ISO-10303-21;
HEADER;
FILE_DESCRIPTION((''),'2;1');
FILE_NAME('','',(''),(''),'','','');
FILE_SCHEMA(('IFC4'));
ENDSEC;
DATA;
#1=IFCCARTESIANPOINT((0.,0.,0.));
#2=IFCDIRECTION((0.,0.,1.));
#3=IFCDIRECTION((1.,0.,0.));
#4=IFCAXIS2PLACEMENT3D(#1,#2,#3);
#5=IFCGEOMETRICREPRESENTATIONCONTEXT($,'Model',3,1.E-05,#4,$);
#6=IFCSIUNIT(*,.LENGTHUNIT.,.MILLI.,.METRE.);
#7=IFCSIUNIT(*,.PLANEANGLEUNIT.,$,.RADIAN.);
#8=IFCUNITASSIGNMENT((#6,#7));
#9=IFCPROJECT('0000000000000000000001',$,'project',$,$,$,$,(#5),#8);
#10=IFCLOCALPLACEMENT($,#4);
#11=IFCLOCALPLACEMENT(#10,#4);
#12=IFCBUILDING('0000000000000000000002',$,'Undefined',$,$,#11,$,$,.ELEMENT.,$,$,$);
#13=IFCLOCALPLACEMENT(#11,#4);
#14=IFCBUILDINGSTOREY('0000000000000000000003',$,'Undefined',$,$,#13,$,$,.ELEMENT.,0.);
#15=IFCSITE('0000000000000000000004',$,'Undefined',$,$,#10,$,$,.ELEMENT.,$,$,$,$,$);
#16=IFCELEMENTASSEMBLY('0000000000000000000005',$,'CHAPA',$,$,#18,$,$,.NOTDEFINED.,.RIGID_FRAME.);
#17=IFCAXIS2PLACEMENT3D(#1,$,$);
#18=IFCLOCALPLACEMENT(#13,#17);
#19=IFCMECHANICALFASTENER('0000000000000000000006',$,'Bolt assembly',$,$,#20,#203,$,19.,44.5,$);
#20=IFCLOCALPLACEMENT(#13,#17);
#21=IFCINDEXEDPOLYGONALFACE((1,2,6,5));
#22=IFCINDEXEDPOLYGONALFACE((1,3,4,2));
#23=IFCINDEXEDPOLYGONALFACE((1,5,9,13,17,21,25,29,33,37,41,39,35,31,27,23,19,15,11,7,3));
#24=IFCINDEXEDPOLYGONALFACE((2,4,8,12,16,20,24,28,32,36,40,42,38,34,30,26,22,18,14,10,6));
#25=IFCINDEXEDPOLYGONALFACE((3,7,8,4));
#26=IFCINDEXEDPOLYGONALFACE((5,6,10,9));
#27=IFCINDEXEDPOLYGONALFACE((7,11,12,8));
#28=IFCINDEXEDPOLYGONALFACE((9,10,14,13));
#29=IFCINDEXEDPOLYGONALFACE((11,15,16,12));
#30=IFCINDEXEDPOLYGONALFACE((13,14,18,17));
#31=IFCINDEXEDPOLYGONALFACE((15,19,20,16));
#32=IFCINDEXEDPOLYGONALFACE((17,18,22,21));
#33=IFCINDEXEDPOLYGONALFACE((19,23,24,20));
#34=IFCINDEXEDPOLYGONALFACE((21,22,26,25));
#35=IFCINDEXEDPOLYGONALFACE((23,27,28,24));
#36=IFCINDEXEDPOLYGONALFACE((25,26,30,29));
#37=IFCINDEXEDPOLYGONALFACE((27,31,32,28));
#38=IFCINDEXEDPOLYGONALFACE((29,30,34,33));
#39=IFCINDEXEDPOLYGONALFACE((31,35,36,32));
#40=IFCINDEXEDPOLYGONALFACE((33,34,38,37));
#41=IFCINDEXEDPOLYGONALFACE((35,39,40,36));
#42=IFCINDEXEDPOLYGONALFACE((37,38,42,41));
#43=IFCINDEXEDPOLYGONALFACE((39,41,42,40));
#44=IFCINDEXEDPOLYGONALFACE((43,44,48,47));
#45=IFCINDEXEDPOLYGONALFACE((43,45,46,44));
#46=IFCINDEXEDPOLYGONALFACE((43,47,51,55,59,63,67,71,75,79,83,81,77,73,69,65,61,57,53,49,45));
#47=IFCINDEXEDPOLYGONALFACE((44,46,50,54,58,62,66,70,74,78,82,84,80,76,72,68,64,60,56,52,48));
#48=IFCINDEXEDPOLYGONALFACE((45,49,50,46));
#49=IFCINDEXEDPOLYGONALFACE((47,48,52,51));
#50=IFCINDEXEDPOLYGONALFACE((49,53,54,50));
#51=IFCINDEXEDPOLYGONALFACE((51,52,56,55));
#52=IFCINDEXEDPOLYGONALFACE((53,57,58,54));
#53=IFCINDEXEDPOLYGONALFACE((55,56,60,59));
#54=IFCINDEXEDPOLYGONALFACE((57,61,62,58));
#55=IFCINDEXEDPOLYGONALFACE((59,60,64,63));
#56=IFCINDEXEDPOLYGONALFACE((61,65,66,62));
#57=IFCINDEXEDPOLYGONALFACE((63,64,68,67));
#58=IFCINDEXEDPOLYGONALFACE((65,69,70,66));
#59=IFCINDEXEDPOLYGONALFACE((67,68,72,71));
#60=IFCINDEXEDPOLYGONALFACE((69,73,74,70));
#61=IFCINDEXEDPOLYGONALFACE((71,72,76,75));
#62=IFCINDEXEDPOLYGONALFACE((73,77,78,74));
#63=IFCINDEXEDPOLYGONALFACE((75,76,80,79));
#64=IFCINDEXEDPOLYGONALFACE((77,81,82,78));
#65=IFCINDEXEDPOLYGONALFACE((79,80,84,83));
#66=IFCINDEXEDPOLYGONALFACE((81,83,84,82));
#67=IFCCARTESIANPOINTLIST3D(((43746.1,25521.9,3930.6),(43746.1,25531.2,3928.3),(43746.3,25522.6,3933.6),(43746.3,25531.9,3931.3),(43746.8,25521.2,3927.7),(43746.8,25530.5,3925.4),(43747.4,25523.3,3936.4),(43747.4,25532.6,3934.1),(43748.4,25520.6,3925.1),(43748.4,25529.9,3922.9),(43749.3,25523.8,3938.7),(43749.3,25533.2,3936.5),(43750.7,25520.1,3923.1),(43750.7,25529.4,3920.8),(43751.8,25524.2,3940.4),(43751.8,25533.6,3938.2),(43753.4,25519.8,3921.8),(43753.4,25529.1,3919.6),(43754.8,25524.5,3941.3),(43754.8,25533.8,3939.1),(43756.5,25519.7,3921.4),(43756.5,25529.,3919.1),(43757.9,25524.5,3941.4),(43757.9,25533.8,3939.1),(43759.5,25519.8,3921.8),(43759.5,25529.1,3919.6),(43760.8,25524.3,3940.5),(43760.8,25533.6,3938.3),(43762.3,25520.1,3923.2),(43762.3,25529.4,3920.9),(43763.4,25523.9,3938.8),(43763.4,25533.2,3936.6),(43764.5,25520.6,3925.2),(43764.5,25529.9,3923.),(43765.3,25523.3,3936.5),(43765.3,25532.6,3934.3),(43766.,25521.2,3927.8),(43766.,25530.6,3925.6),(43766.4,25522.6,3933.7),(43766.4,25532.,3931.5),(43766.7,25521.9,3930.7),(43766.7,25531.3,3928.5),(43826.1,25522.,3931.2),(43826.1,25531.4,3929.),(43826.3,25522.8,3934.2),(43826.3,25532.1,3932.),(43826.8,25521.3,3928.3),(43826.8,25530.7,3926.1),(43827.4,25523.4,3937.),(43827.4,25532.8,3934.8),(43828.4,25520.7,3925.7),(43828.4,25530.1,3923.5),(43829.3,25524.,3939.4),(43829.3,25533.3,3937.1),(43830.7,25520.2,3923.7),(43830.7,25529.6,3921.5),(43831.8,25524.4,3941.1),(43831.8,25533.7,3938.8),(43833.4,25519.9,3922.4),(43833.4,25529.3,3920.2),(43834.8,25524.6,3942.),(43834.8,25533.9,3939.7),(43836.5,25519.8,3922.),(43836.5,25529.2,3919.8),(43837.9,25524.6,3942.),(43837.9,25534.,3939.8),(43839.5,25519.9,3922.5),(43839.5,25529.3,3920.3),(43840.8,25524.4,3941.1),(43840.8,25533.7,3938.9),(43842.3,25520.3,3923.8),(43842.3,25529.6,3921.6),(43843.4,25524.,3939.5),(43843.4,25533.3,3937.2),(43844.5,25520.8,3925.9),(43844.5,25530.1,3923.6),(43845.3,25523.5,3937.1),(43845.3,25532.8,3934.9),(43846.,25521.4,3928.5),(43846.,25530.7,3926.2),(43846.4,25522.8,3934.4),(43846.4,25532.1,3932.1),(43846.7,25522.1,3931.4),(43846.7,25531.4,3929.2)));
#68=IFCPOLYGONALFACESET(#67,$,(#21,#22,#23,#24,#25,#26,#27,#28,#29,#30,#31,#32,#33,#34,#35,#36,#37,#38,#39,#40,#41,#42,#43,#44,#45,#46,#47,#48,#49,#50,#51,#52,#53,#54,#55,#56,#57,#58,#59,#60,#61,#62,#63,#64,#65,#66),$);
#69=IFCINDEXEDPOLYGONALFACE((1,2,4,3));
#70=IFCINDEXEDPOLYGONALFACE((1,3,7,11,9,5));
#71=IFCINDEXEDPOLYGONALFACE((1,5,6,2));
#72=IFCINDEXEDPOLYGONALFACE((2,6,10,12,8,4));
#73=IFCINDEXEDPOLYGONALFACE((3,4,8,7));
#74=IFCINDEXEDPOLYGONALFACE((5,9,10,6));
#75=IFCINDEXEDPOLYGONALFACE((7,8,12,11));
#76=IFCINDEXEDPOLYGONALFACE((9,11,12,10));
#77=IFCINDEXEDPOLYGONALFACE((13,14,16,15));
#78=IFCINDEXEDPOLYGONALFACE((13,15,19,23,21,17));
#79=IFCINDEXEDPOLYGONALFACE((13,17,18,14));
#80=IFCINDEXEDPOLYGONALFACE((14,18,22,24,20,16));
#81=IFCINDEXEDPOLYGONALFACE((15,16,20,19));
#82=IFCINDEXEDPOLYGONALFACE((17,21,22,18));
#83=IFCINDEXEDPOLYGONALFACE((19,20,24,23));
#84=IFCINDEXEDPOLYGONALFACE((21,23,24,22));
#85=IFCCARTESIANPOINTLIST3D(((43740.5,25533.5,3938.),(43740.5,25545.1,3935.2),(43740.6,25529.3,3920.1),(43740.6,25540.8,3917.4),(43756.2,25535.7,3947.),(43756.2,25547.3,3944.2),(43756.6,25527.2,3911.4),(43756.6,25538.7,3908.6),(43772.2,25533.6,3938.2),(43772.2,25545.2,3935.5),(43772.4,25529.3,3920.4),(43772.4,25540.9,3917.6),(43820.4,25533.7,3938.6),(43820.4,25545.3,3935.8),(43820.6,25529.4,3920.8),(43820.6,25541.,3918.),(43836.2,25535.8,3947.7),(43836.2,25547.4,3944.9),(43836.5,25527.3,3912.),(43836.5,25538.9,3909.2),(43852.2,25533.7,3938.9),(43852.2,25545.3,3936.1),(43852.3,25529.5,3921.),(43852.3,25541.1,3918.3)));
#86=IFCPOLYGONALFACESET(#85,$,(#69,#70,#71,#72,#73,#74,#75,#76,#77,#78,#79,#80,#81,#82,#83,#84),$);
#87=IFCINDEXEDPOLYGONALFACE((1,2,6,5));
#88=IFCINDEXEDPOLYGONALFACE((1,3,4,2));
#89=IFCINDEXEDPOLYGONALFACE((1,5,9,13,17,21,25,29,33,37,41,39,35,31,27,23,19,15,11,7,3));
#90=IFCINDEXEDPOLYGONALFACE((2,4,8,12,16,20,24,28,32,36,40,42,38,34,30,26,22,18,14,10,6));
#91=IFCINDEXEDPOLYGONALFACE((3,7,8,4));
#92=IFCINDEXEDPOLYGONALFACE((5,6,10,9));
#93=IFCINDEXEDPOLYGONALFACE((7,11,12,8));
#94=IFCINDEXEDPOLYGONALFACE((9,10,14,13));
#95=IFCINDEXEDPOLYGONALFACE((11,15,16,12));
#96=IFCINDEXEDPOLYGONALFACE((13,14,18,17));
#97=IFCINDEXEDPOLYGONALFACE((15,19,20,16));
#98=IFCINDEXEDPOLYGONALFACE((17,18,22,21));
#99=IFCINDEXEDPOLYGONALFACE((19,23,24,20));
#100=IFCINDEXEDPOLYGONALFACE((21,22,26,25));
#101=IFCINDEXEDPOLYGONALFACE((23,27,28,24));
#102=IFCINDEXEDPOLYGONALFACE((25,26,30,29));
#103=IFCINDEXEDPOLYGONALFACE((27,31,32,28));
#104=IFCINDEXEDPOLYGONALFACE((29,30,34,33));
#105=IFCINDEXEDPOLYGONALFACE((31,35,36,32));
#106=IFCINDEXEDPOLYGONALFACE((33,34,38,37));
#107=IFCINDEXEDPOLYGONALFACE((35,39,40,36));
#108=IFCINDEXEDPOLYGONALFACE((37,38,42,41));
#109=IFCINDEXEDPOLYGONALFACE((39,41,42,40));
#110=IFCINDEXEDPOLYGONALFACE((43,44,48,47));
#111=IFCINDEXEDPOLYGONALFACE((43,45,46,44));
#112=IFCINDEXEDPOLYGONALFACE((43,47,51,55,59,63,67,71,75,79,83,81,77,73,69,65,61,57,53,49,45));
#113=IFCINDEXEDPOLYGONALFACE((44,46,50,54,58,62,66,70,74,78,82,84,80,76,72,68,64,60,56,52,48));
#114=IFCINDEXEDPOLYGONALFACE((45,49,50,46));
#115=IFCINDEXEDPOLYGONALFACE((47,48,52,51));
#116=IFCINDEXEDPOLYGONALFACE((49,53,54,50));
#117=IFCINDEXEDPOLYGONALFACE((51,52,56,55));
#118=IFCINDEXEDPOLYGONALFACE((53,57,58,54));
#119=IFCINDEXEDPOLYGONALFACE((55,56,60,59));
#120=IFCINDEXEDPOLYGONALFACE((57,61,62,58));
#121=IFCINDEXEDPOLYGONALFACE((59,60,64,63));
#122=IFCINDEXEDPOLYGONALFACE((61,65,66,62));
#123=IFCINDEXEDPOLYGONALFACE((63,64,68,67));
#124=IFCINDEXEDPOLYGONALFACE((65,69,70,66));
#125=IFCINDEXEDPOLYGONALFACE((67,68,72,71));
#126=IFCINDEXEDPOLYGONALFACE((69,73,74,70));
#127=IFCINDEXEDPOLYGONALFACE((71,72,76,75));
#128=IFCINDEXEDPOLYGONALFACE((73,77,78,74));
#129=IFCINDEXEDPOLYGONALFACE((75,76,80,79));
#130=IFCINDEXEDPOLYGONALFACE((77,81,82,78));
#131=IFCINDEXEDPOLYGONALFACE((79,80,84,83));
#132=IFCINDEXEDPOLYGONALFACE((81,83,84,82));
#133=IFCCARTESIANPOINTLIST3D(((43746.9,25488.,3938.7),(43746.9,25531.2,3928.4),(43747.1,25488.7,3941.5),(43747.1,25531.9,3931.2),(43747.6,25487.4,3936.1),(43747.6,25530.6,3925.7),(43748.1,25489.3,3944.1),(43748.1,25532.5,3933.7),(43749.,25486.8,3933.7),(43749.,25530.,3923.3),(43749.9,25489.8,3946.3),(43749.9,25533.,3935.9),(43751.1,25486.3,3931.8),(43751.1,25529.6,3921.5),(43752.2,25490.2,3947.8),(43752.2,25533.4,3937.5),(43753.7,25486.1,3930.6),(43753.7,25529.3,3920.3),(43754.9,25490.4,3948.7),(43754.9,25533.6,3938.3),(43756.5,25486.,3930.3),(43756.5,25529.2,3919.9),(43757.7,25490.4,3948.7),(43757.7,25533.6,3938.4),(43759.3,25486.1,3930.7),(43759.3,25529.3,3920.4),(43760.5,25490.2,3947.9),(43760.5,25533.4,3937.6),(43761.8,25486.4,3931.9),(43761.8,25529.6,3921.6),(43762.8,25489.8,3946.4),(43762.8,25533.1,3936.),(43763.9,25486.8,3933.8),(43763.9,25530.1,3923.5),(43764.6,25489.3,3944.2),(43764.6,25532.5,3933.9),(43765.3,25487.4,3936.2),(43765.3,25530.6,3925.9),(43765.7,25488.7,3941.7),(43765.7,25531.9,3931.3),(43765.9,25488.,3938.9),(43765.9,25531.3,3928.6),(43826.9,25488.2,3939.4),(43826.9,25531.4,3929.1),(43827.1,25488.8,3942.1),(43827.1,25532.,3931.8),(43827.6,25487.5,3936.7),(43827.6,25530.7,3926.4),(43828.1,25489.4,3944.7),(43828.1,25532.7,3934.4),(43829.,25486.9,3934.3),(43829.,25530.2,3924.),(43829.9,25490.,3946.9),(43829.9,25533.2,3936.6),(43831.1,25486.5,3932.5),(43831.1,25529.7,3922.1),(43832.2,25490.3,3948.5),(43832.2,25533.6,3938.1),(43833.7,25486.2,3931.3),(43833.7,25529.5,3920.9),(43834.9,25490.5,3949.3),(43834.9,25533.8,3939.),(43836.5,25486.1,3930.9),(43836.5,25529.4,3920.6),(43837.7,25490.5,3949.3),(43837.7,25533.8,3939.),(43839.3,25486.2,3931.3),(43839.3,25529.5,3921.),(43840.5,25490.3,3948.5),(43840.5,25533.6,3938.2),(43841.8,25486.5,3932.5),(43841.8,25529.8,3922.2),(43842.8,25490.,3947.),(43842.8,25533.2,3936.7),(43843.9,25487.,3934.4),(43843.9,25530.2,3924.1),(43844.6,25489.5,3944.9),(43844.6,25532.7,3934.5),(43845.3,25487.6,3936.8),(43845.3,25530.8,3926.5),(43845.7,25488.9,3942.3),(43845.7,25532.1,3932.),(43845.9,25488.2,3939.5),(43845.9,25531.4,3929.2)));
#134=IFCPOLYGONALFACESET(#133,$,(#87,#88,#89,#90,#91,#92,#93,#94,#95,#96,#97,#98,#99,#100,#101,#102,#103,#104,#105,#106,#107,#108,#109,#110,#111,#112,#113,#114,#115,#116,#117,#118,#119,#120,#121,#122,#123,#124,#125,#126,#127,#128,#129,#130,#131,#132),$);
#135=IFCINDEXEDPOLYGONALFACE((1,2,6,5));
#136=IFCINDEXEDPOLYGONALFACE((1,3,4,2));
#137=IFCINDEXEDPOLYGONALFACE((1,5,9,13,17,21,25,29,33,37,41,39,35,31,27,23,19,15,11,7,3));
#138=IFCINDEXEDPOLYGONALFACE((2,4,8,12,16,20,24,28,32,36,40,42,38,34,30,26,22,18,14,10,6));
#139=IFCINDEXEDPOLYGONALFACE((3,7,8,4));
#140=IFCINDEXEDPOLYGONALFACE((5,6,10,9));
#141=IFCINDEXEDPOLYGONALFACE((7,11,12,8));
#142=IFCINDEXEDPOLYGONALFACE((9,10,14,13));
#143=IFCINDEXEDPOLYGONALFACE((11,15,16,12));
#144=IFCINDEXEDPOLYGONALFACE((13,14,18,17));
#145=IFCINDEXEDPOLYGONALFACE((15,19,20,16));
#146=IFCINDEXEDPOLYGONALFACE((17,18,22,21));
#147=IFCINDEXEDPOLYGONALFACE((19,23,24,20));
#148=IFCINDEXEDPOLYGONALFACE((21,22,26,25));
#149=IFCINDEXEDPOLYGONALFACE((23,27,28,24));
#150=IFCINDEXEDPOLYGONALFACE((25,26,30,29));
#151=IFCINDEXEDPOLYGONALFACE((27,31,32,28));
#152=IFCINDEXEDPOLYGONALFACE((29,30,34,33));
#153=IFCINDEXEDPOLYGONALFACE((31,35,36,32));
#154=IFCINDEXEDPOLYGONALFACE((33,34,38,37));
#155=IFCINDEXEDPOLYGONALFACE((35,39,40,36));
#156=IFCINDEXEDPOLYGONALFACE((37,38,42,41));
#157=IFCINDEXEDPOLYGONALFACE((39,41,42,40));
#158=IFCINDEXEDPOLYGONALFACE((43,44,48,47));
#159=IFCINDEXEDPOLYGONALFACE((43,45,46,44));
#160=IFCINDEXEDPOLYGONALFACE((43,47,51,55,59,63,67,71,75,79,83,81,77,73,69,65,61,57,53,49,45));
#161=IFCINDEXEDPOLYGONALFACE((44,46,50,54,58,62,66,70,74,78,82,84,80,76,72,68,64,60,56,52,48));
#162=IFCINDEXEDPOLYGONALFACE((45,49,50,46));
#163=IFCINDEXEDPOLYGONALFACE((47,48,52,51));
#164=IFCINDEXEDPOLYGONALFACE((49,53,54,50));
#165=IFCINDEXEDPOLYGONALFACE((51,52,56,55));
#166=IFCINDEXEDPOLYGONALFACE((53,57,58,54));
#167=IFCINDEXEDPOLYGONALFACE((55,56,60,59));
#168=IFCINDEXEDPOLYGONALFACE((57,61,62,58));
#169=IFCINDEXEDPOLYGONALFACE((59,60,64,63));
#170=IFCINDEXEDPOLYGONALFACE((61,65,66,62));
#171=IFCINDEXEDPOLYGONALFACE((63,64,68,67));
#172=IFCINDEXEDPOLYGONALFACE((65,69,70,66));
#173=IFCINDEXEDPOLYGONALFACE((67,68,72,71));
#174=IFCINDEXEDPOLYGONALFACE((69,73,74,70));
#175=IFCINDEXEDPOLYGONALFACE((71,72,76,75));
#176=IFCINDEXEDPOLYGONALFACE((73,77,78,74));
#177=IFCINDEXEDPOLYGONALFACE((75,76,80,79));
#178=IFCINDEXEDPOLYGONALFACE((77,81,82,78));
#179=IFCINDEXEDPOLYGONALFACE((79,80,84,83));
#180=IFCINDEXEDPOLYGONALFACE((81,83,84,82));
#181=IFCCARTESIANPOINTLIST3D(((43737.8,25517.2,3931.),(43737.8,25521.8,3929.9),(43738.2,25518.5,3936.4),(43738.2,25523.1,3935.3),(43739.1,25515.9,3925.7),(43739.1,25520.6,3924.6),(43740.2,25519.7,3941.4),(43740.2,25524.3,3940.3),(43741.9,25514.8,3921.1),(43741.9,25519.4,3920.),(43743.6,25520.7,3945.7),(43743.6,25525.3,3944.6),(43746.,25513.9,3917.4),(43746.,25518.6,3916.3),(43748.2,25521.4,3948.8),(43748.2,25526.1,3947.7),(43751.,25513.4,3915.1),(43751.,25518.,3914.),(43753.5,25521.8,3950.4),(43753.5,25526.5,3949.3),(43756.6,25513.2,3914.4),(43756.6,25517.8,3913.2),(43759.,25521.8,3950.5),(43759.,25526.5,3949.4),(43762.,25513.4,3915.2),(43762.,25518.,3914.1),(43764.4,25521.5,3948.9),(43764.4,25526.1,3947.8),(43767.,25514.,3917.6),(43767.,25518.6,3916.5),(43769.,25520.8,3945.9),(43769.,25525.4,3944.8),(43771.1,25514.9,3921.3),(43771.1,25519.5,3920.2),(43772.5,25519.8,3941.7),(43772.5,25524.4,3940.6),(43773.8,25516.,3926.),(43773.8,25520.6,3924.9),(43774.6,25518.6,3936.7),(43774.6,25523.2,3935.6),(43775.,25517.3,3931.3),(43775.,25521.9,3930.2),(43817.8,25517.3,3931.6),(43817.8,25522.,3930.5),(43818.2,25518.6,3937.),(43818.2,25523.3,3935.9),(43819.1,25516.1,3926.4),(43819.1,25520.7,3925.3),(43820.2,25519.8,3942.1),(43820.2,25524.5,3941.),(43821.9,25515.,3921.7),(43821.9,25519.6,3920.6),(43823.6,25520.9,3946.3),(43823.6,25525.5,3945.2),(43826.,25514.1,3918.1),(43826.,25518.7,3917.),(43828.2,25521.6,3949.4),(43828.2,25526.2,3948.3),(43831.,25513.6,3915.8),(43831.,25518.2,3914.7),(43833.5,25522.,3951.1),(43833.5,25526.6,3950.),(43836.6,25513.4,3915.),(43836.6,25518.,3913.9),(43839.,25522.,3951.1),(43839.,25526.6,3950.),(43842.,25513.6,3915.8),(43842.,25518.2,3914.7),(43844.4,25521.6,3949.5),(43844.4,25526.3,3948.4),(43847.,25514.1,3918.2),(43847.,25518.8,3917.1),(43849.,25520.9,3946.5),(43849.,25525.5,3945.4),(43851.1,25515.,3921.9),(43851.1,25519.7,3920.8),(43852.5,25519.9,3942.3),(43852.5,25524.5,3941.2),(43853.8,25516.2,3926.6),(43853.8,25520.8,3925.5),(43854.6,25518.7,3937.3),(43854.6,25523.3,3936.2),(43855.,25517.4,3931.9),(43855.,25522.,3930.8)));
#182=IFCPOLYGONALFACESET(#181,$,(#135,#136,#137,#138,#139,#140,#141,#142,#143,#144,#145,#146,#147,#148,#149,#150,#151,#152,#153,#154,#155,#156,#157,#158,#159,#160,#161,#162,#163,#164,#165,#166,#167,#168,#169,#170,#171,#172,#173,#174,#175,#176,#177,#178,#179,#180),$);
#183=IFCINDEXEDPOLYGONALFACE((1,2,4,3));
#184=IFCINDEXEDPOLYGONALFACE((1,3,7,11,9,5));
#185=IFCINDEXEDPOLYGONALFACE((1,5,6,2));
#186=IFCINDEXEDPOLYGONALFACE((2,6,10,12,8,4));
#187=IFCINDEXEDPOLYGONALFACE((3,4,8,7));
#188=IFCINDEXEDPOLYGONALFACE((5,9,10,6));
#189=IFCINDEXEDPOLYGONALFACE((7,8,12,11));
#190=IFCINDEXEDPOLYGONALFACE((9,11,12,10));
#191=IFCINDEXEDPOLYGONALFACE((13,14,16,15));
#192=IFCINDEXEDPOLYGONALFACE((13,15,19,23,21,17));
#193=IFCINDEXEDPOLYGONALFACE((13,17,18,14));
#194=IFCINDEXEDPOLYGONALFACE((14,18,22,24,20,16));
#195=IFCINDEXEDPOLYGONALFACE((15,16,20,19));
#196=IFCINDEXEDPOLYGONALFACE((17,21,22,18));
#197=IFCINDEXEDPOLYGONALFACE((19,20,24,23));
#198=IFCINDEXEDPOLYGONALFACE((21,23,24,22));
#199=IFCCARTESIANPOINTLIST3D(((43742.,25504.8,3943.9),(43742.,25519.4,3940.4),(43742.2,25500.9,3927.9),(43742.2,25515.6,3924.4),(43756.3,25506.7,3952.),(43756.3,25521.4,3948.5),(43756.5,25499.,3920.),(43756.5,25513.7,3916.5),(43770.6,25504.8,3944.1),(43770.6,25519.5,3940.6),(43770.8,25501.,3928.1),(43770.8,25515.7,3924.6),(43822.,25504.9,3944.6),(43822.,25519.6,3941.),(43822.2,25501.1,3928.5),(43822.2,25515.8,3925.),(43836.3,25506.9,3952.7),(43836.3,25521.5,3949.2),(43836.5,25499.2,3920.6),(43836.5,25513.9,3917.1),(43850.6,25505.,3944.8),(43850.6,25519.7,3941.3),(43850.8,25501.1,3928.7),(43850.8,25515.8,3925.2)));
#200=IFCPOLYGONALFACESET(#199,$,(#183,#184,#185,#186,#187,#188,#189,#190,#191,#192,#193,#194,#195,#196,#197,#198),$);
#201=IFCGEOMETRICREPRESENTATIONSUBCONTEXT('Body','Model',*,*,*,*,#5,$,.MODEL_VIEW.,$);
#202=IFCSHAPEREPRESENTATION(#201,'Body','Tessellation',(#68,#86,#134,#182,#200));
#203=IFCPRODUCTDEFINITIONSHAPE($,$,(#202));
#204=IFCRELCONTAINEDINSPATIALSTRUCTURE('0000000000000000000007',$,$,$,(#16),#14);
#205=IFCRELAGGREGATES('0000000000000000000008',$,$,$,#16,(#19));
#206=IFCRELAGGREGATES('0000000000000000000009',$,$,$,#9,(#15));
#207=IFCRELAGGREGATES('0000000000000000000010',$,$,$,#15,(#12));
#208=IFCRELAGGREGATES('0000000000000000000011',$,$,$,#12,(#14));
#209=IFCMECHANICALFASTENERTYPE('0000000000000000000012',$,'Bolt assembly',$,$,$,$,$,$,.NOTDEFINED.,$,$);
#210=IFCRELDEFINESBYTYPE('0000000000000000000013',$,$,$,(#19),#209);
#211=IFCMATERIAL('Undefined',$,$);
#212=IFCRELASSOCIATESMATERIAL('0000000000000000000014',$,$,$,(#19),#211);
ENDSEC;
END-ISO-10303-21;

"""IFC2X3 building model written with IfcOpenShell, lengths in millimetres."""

from ifc_helpers import new_model, si_unit, frame, origin_with_axes, origin_2d_with_axis, place, context, subcontext, project, spatial, polyline, circle, outline, extrude, source, transform, mapped, material, type_object, element, aggregate, save


model = new_model("IFC2X3")

# Units and contexts
model_context = context("Model", 3, precision=1e-05, world=origin_with_axes())
body_context = subcontext(model_context, "Body", "Model", "MODEL_VIEW")
ifc_project = project(units=[si_unit("LENGTHUNIT", "METRE", prefix="MILLI"), si_unit("PLANEANGLEUNIT", "RADIAN")], contexts=[model_context])

# Site, building, storey
site_placement = place(None, origin_with_axes())
site = spatial("IfcSite", under=ifc_project, at=site_placement, Name="Undefined", CompositionType="ELEMENT")
building_placement = place(site_placement, origin_with_axes())
building = spatial("IfcBuilding", under=site, at=building_placement, Name="Undefined", CompositionType="ELEMENT")
storey_placement = place(building_placement, origin_with_axes())
storey = spatial("IfcBuildingStorey", under=building, at=storey_placement, Name="Undefined", CompositionType="ELEMENT", Elevation=0.0)

# Element assembly
assembly_1_placement = place(storey_placement, origin_with_axes())
assembly_1 = element("IfcElementAssembly", 1, at=assembly_1_placement, inside=storey, Name="CHAPA", AssemblyPlace="NOTDEFINED", PredefinedType="RIGID_FRAME")

# Shared definitions
ifc_material_1 = material(Name="Undefined")
mechanical_fastener_type = type_object("IfcMechanicalFastenerType", Name="Bolt assembly")

# Mechanical fastener
shared_shape_1 = source(origin_with_axes(), body_context, "Body", "SweptSolid", [
    extrude(circle(Radius=10.3, at=origin_2d_with_axis()), frame((0.0, 0.0, 0.0), z_axis=(0.0, 1.0, 0.0), x_axis=(1.0, 0.0, 0.0)), (0.0, 0.0, 1.0), 9.6),
    extrude(outline(polyline([(18.3, 0.0), (9.2, 15.9), (-9.2, 15.9), (-18.3, 0.0), (-9.2, -15.9), (9.2, -15.9), (18.3, 0.0)])), frame((0.0, -11.9, 0.0), z_axis=(0.0, 1.0, 0.0), x_axis=(1.0, 0.0, 0.0)), (0.0, 0.0, 1.0), 11.9),
    extrude(circle(Radius=9.5, at=origin_2d_with_axis()), frame((0.0, 0.0, 0.0), z_axis=(0.0, 1.0, 0.0), x_axis=(1.0, 0.0, 0.0)), (0.0, 0.0, 1.0), 44.5),
    extrude(circle(Radius=18.7, at=origin_2d_with_axis()), frame((0.0, 9.5, 0.0), z_axis=(0.0, 1.0, 0.0), x_axis=(1.0, 0.0, 0.0)), (0.0, 0.0, 1.0), 4.8),
    extrude(outline(polyline([(16.5, 0.0), (8.2, 14.3), (-8.2, 14.3), (-16.5, 0.0), (-8.2, -14.3), (8.2, -14.3), (16.5, 0.0)])), frame((0.0, 14.3, 0.0), z_axis=(0.0, 1.0, 0.0), x_axis=(1.0, 0.0, 0.0)), (0.0, 0.0, 1.0), 15.1),
])
mechanical_fastener_1_placement = place(assembly_1_placement, frame((43796.4, 25531.5, 3929.5), z_axis=(-0.999966, -0.001919, -0.008026), x_axis=(0.008253, -0.23249, -0.972564)))
mechanical_fastener_1 = element("IfcMechanicalFastener", 2, at=mechanical_fastener_1_placement, type_object=mechanical_fastener_type, material=ifc_material_1, Name="Bolt assembly", NominalDiameter=19.0, NominalLength=44.5, context=body_context, shape_type="MappedRepresentation", body=[
    mapped(shared_shape_1, transform((0.0, 0.0, 40.0))),
    mapped(shared_shape_1, transform((0.0, 0.0, -40.0))),
])
aggregate(assembly_1, [mechanical_fastener_1])

save(model, "model.ifc")
